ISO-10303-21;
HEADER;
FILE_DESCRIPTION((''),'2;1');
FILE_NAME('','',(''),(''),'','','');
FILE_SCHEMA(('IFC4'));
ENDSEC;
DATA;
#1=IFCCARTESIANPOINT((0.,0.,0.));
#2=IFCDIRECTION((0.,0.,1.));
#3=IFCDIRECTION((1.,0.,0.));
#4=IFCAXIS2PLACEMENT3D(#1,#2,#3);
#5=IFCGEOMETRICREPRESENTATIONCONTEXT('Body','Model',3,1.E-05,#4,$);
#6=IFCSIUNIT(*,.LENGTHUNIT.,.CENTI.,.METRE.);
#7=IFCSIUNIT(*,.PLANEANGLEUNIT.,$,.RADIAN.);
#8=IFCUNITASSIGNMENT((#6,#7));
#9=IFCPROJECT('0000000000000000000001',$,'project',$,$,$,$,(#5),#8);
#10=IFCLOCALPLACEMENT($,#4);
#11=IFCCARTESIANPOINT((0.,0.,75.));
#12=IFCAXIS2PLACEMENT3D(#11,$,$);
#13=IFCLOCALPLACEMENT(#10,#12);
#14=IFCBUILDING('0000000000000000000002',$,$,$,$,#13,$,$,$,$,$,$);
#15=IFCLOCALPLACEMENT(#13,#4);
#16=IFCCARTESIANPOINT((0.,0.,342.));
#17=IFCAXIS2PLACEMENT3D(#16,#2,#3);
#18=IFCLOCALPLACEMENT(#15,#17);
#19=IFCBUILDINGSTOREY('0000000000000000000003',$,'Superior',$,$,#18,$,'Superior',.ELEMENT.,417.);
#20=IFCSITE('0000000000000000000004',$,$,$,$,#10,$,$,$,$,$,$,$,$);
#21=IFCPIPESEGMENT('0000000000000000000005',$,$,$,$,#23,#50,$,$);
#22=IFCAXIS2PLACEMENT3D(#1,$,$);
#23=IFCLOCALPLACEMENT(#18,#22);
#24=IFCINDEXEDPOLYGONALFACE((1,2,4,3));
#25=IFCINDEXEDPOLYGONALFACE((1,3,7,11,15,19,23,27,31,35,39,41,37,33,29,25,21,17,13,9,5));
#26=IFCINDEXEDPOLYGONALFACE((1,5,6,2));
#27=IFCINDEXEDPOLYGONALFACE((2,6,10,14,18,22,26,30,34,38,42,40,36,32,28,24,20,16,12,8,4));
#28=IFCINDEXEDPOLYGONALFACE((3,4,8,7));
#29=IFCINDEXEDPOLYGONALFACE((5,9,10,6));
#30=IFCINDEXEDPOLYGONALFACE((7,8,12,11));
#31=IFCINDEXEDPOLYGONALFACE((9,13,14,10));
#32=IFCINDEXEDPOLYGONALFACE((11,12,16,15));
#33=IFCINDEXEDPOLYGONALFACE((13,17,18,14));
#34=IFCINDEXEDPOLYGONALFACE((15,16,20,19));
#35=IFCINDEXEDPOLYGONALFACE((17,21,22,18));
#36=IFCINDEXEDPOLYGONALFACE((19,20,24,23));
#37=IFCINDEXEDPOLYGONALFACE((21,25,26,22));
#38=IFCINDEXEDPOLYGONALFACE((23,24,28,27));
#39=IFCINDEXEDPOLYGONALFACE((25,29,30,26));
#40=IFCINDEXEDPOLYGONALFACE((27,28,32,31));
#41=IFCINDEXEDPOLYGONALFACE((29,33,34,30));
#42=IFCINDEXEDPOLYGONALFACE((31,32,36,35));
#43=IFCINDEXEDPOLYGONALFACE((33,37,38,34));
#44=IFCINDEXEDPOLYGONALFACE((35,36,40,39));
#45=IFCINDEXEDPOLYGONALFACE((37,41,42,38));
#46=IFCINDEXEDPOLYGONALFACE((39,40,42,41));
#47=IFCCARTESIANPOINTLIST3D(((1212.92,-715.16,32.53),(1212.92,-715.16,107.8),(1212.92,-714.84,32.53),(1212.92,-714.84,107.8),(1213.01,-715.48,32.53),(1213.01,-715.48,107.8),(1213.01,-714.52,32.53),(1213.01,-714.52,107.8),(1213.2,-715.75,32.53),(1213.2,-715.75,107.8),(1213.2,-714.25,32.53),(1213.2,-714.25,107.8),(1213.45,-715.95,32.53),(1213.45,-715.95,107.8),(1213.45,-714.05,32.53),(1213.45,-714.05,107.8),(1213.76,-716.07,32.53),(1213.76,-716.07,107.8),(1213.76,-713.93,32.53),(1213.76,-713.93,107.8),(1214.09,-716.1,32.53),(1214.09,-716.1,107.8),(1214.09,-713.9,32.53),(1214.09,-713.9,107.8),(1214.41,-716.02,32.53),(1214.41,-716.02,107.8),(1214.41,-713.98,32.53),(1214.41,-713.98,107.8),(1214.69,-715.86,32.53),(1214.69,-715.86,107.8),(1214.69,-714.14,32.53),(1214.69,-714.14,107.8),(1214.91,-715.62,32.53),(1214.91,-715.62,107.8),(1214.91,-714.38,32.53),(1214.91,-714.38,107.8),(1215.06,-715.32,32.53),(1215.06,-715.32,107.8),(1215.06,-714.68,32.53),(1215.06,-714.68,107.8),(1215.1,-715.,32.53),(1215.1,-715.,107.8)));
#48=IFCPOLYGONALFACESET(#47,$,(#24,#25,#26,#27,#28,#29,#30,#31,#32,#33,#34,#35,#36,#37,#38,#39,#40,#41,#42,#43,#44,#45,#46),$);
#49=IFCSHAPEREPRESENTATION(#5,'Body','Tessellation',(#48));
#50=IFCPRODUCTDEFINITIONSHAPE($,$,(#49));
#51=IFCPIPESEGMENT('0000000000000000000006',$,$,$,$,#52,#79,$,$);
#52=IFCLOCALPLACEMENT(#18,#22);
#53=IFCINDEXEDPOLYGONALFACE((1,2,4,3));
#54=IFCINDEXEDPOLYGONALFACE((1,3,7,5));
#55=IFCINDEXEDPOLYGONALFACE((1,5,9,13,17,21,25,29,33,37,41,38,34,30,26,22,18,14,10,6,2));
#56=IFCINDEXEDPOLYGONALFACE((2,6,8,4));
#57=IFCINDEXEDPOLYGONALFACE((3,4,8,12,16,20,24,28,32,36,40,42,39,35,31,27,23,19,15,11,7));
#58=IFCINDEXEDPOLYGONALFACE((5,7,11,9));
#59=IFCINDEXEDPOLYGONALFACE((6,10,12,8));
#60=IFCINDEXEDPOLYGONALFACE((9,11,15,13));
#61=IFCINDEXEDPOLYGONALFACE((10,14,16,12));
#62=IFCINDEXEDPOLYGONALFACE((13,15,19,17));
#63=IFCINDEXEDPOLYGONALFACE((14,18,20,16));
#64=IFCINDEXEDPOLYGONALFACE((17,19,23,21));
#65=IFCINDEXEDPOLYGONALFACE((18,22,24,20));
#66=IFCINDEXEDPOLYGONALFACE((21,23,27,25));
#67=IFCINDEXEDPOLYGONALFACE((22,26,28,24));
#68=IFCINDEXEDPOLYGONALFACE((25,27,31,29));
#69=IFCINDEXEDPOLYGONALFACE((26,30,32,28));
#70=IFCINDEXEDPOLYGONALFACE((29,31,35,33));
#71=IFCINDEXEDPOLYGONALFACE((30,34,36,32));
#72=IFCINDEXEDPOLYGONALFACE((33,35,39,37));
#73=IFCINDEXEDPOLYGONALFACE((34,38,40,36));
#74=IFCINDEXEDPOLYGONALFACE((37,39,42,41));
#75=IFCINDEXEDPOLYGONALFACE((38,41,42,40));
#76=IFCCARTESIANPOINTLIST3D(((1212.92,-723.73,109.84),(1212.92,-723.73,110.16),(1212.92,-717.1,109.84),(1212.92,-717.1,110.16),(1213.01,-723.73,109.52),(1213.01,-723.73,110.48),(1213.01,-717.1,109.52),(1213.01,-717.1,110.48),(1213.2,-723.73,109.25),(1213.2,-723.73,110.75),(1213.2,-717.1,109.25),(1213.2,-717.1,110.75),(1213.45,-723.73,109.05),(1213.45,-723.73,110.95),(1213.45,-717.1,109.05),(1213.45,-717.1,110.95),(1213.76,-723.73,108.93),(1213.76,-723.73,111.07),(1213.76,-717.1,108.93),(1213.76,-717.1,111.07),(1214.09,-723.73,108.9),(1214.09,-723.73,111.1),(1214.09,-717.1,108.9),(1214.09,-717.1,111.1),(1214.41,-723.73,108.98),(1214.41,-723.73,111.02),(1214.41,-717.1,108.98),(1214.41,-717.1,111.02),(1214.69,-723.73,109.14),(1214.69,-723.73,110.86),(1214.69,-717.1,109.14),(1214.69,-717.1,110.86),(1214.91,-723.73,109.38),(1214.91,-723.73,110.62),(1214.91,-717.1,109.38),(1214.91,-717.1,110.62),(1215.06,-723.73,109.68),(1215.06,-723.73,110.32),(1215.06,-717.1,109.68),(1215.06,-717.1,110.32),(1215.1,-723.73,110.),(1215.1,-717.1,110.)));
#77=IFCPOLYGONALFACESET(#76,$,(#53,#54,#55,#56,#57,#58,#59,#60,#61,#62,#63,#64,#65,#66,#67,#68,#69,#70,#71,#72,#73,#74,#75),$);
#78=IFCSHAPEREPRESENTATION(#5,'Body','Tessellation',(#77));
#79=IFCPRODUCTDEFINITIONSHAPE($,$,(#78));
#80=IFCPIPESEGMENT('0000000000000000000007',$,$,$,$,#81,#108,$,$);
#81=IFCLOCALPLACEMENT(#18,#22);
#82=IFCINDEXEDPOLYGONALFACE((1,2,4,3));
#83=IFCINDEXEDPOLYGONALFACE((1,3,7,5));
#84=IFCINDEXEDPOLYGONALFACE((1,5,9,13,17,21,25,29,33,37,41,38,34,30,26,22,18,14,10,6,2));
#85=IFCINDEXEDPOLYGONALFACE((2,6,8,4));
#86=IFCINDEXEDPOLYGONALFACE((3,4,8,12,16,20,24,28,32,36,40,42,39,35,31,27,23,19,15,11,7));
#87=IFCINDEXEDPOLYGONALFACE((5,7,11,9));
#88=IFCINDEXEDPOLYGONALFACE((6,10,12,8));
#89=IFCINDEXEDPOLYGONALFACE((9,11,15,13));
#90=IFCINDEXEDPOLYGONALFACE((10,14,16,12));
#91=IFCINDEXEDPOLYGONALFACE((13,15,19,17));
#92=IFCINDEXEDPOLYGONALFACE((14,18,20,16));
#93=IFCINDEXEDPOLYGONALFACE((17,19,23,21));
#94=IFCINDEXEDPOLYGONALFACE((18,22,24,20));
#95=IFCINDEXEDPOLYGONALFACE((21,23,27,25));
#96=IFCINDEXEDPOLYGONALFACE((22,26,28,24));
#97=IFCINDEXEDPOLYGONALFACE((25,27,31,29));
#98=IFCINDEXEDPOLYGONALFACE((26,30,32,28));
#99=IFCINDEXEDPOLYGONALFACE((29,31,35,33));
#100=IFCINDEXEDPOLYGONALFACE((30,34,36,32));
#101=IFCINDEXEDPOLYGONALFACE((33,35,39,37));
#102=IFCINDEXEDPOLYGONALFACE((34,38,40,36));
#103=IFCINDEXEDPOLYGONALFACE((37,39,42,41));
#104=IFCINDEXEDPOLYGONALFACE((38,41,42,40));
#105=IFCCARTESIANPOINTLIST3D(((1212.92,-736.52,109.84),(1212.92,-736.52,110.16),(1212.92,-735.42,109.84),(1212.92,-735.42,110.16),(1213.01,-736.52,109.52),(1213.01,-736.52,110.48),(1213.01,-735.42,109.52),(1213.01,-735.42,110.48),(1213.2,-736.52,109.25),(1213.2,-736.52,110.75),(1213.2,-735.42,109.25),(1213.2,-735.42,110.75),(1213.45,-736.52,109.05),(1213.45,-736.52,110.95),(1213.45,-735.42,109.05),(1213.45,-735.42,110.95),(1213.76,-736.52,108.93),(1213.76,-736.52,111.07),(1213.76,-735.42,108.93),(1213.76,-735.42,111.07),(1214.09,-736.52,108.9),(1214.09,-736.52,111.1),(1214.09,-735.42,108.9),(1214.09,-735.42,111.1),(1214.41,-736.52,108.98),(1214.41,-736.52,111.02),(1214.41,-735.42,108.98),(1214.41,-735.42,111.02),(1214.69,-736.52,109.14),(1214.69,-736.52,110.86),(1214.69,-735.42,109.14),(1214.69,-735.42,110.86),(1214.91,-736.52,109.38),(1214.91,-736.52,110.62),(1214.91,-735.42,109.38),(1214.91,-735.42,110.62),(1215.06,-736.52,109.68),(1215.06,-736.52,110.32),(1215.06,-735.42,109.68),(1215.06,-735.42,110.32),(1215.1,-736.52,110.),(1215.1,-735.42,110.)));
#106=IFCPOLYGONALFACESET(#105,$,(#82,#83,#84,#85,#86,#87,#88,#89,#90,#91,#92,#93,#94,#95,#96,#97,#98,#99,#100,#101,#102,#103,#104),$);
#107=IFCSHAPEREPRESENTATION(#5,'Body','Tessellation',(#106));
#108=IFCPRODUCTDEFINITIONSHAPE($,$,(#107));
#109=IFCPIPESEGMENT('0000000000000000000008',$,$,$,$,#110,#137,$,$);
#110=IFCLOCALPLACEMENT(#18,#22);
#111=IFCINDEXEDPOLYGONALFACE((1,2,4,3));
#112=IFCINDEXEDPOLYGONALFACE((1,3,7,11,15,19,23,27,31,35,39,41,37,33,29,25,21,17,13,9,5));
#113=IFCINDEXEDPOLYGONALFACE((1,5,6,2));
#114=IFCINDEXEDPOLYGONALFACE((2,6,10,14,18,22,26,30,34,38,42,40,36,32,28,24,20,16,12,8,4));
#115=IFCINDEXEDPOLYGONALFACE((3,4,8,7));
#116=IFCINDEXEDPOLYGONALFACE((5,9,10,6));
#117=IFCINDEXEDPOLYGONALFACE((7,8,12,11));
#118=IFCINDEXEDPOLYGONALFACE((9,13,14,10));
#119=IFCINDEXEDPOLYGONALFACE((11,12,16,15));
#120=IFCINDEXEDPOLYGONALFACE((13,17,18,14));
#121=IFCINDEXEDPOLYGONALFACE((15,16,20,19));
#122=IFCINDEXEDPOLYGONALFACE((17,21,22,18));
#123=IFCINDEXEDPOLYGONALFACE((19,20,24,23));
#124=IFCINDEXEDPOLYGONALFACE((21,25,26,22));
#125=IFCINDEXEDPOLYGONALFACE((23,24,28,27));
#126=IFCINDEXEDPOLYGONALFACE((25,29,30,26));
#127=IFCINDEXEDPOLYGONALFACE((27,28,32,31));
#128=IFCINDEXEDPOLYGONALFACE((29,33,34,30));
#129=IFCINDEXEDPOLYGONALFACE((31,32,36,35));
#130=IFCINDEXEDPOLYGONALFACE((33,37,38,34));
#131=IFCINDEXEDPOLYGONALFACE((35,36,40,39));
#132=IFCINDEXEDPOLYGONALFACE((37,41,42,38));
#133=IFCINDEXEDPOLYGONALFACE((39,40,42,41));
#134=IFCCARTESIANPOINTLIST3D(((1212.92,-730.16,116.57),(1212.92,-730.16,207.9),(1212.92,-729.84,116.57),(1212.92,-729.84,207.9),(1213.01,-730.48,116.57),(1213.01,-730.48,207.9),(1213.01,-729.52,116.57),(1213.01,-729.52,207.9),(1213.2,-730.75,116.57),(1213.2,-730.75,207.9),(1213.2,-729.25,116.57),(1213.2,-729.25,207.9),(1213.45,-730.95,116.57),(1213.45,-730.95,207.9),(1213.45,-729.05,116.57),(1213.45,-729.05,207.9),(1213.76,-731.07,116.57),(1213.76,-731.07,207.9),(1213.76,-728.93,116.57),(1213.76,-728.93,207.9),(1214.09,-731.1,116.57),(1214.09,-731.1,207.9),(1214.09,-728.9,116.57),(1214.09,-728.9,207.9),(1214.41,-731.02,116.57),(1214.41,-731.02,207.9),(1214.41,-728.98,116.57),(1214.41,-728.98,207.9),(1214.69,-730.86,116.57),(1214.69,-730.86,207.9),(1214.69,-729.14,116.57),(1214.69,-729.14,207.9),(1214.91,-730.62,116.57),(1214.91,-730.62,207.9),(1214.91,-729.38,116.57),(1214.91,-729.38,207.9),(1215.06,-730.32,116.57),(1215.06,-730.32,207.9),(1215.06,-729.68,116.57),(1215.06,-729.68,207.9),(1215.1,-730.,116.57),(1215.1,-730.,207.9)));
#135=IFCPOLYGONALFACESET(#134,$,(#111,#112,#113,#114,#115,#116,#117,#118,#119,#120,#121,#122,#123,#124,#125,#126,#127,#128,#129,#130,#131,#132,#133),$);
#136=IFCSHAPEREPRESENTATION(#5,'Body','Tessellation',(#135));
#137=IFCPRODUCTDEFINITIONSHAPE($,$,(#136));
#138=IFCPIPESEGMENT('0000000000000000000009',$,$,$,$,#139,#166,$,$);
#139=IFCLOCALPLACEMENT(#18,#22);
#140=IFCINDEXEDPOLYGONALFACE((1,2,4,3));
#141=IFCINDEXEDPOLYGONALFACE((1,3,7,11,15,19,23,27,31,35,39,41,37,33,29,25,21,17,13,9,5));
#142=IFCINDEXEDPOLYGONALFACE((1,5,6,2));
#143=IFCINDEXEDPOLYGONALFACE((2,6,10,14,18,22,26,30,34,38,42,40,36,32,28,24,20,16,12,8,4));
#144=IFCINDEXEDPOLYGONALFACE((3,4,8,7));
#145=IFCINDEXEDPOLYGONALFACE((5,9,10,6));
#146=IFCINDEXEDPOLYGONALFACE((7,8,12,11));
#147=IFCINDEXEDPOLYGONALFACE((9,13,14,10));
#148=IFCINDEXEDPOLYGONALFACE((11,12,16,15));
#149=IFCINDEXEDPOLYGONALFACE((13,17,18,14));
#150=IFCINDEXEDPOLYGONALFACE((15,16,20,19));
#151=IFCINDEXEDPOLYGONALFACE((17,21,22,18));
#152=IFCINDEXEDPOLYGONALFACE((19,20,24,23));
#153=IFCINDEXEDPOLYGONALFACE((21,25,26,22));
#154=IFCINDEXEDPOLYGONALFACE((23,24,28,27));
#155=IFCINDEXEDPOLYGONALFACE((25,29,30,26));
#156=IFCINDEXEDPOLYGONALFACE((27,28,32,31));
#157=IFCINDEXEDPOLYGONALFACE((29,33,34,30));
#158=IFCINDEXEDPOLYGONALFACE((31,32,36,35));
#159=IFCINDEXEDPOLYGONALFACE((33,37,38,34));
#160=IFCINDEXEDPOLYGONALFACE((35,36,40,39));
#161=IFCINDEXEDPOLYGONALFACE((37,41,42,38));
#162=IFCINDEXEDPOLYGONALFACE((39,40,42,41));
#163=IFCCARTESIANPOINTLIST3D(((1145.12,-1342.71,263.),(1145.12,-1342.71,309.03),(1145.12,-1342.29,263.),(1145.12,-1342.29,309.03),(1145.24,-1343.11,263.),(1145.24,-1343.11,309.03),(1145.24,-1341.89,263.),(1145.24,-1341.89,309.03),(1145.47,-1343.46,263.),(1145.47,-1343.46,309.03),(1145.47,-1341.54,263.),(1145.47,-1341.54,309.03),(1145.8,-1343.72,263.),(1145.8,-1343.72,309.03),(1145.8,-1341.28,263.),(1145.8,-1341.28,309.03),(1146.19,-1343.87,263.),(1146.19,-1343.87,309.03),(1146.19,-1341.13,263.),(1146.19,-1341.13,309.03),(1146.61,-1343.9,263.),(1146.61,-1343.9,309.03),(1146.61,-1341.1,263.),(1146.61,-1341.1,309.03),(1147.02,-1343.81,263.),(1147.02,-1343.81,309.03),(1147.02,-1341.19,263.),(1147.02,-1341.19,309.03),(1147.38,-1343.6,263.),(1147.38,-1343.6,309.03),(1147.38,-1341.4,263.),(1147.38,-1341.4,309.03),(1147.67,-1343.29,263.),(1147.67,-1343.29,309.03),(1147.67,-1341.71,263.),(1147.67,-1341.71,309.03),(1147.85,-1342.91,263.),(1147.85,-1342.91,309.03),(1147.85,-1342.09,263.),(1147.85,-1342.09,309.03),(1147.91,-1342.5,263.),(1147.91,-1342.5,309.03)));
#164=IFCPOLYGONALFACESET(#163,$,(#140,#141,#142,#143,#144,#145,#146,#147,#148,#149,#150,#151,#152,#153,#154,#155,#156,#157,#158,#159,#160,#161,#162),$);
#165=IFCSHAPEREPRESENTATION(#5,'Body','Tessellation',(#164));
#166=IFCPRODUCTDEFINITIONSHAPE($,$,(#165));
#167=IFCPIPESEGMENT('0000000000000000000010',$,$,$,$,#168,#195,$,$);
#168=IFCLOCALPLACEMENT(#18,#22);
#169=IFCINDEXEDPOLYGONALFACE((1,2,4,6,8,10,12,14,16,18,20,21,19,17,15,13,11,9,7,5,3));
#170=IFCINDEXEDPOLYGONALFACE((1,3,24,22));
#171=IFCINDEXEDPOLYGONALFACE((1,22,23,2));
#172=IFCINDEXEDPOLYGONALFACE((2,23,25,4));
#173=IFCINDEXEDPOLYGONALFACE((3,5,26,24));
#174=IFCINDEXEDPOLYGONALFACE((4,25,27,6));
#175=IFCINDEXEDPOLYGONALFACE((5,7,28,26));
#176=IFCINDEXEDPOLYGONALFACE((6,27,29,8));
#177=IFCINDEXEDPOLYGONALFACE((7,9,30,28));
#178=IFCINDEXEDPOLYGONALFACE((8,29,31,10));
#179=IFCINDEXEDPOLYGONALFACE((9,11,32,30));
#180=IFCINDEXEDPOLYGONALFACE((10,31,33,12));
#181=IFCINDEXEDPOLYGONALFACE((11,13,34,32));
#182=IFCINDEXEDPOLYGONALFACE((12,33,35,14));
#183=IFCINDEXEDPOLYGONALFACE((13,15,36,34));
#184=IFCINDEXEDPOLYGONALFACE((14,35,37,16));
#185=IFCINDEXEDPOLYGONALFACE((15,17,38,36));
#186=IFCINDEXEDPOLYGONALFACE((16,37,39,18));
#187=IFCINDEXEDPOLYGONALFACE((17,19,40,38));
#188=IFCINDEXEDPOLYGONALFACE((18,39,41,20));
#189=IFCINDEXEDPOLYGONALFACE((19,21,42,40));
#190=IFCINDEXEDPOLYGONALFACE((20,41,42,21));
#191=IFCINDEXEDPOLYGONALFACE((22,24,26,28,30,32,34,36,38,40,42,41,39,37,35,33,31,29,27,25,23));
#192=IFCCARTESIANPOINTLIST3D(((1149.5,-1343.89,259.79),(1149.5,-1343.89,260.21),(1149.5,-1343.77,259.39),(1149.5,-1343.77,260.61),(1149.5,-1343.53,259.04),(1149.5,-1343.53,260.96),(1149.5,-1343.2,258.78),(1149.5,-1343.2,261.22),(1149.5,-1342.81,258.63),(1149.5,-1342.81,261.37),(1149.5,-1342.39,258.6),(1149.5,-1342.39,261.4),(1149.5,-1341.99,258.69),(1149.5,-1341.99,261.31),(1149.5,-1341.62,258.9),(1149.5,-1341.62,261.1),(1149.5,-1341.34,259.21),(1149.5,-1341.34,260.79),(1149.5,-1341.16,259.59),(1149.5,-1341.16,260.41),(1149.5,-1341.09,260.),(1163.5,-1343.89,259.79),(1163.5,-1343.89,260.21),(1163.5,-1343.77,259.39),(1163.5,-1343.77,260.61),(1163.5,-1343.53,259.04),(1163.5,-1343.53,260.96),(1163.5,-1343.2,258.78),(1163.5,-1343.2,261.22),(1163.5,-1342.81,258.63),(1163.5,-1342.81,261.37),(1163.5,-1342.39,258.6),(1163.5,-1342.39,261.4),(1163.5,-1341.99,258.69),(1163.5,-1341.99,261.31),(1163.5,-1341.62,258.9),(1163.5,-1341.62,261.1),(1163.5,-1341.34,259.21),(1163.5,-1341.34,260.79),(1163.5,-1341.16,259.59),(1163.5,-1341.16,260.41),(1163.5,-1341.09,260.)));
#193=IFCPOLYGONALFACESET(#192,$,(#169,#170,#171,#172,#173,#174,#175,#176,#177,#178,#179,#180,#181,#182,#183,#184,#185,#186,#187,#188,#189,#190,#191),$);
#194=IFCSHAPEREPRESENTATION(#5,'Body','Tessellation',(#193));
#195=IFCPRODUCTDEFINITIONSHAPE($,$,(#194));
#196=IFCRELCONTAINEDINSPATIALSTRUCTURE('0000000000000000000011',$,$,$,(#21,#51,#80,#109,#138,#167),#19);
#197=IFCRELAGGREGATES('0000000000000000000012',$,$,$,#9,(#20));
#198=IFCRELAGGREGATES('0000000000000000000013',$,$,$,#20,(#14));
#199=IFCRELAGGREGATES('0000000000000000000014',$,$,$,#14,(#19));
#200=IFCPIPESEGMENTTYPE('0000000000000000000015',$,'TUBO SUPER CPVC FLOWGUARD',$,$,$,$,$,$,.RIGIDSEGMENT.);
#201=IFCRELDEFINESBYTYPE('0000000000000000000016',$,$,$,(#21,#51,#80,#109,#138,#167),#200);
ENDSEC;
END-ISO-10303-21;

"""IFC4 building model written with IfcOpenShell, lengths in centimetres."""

from ifc_helpers import new_model, si_unit, frame, origin_with_axes, origin_2d_with_axis, place, context, project, spatial, circle, extrude, type_object, element, save


model = new_model("IFC4")

# Units and contexts
model_context = context("Model", 3, precision=1e-05, world=origin_with_axes(), identifier="Body")
ifc_project = project(units=[si_unit("LENGTHUNIT", "METRE", prefix="CENTI"), si_unit("PLANEANGLEUNIT", "RADIAN")], contexts=[model_context])

# Site, building, storey
site_placement = place(None, origin_with_axes())
site = spatial("IfcSite", under=ifc_project, at=site_placement)
building_placement = place(site_placement, frame((0.0, 0.0, 75.0)))
building = spatial("IfcBuilding", under=site, at=building_placement)
placement = place(building_placement, origin_with_axes())
storey_placement = place(placement, frame((0.0, 0.0, 342.0), z_axis=(0.0, 0.0, 1.0), x_axis=(1.0, 0.0, 0.0)))
storey = spatial("IfcBuildingStorey", under=building, at=storey_placement, Name="Superior", LongName="Superior", CompositionType="ELEMENT", Elevation=417.0)

# Pipe segments
pipe_segment_type_1 = type_object("IfcPipeSegmentType", Name="TUBO SUPER CPVC FLOWGUARD", PredefinedType="RIGIDSEGMENT")
pipe_segment_1_placement = place(storey_placement, frame((1214.0, -715.0, 107.8), z_axis=(0.0, 0.0, 1.0), x_axis=(1.0, 0.0, 0.0)))
element("IfcPipeSegment", 1, at=pipe_segment_1_placement, inside=storey, type_object=pipe_segment_type_1, context=model_context, shape_type="SolidModel", body=[
    extrude(circle(Radius=1.1, at=origin_2d_with_axis()), frame((0.0, 0.0, 0.0), z_axis=(0.0, 0.0, -1.0), x_axis=(1.0, 0.0, 0.0)), (0.0, 0.0, 1.0), 75.27),
])
pipe_segment_2_placement = place(storey_placement, frame((1214.0, -720.41, 111.1), z_axis=(0.0, 0.0, 1.0), x_axis=(1.0, 0.0, 0.0)))
element("IfcPipeSegment", 2, at=pipe_segment_2_placement, inside=storey, type_object=pipe_segment_type_1, context=model_context, shape_type="SolidModel", body=[
    extrude(circle(Radius=1.1, at=origin_2d_with_axis()), frame((0.0, 3.31, -1.1), z_axis=(0.0, -1.0, 0.0), x_axis=(1.0, 0.0, 0.0)), (0.0, 0.0, 1.0), 6.63),
])
pipe_segment_3_placement = place(storey_placement, frame((1214.0, -735.97, 111.1), z_axis=(0.0, 0.0, 1.0), x_axis=(1.0, 0.0, 0.0)))
element("IfcPipeSegment", 3, at=pipe_segment_3_placement, inside=storey, type_object=pipe_segment_type_1, context=model_context, shape_type="SolidModel", body=[
    extrude(circle(Radius=1.1, at=origin_2d_with_axis()), frame((0.0, -0.55, -1.1), z_axis=(0.0, 1.0, 0.0), x_axis=(1.0, 0.0, 0.0)), (0.0, 0.0, 1.0), 1.1),
])
pipe_segment_4_placement = place(storey_placement, frame((1214.0, -730.0, 207.9), z_axis=(0.0, 0.0, 1.0), x_axis=(1.0, 0.0, 0.0)))
element("IfcPipeSegment", 4, at=pipe_segment_4_placement, inside=storey, type_object=pipe_segment_type_1, context=model_context, shape_type="SolidModel", body=[
    extrude(circle(Radius=1.1, at=origin_2d_with_axis()), frame((0.0, 0.0, -91.33), z_axis=(0.0, 0.0, 1.0), x_axis=(1.0, 0.0, 0.0)), (0.0, 0.0, 1.0), 91.33),
])
pipe_segment_5_placement = place(storey_placement, frame((1146.5, -1342.5, 309.03), z_axis=(0.0, 0.0, 1.0), x_axis=(1.0, 0.0, 0.0)))
element("IfcPipeSegment", 5, at=pipe_segment_5_placement, inside=storey, type_object=pipe_segment_type_1, context=model_context, shape_type="SolidModel", body=[
    extrude(circle(Radius=1.41, at=origin_2d_with_axis()), frame((0.0, 0.0, 0.0), z_axis=(0.0, 0.0, -1.0), x_axis=(1.0, 0.0, 0.0)), (0.0, 0.0, 1.0), 46.03),
])
pipe_segment_6_placement = place(storey_placement, frame((1156.5, -1342.5, 261.4), z_axis=(0.0, 0.0, 1.0), x_axis=(1.0, 0.0, 0.0)))
element("IfcPipeSegment", 6, at=pipe_segment_6_placement, inside=storey, type_object=pipe_segment_type_1, context=model_context, shape_type="SolidModel", body=[
    extrude(circle(Radius=1.41, at=origin_2d_with_axis()), frame((-7.0, 0.0, -1.41), z_axis=(1.0, 0.0, 0.0), x_axis=(0.0, 1.0, 0.0)), (0.0, 0.0, 1.0), 14.0),
])

save(model, "model.ifc")
